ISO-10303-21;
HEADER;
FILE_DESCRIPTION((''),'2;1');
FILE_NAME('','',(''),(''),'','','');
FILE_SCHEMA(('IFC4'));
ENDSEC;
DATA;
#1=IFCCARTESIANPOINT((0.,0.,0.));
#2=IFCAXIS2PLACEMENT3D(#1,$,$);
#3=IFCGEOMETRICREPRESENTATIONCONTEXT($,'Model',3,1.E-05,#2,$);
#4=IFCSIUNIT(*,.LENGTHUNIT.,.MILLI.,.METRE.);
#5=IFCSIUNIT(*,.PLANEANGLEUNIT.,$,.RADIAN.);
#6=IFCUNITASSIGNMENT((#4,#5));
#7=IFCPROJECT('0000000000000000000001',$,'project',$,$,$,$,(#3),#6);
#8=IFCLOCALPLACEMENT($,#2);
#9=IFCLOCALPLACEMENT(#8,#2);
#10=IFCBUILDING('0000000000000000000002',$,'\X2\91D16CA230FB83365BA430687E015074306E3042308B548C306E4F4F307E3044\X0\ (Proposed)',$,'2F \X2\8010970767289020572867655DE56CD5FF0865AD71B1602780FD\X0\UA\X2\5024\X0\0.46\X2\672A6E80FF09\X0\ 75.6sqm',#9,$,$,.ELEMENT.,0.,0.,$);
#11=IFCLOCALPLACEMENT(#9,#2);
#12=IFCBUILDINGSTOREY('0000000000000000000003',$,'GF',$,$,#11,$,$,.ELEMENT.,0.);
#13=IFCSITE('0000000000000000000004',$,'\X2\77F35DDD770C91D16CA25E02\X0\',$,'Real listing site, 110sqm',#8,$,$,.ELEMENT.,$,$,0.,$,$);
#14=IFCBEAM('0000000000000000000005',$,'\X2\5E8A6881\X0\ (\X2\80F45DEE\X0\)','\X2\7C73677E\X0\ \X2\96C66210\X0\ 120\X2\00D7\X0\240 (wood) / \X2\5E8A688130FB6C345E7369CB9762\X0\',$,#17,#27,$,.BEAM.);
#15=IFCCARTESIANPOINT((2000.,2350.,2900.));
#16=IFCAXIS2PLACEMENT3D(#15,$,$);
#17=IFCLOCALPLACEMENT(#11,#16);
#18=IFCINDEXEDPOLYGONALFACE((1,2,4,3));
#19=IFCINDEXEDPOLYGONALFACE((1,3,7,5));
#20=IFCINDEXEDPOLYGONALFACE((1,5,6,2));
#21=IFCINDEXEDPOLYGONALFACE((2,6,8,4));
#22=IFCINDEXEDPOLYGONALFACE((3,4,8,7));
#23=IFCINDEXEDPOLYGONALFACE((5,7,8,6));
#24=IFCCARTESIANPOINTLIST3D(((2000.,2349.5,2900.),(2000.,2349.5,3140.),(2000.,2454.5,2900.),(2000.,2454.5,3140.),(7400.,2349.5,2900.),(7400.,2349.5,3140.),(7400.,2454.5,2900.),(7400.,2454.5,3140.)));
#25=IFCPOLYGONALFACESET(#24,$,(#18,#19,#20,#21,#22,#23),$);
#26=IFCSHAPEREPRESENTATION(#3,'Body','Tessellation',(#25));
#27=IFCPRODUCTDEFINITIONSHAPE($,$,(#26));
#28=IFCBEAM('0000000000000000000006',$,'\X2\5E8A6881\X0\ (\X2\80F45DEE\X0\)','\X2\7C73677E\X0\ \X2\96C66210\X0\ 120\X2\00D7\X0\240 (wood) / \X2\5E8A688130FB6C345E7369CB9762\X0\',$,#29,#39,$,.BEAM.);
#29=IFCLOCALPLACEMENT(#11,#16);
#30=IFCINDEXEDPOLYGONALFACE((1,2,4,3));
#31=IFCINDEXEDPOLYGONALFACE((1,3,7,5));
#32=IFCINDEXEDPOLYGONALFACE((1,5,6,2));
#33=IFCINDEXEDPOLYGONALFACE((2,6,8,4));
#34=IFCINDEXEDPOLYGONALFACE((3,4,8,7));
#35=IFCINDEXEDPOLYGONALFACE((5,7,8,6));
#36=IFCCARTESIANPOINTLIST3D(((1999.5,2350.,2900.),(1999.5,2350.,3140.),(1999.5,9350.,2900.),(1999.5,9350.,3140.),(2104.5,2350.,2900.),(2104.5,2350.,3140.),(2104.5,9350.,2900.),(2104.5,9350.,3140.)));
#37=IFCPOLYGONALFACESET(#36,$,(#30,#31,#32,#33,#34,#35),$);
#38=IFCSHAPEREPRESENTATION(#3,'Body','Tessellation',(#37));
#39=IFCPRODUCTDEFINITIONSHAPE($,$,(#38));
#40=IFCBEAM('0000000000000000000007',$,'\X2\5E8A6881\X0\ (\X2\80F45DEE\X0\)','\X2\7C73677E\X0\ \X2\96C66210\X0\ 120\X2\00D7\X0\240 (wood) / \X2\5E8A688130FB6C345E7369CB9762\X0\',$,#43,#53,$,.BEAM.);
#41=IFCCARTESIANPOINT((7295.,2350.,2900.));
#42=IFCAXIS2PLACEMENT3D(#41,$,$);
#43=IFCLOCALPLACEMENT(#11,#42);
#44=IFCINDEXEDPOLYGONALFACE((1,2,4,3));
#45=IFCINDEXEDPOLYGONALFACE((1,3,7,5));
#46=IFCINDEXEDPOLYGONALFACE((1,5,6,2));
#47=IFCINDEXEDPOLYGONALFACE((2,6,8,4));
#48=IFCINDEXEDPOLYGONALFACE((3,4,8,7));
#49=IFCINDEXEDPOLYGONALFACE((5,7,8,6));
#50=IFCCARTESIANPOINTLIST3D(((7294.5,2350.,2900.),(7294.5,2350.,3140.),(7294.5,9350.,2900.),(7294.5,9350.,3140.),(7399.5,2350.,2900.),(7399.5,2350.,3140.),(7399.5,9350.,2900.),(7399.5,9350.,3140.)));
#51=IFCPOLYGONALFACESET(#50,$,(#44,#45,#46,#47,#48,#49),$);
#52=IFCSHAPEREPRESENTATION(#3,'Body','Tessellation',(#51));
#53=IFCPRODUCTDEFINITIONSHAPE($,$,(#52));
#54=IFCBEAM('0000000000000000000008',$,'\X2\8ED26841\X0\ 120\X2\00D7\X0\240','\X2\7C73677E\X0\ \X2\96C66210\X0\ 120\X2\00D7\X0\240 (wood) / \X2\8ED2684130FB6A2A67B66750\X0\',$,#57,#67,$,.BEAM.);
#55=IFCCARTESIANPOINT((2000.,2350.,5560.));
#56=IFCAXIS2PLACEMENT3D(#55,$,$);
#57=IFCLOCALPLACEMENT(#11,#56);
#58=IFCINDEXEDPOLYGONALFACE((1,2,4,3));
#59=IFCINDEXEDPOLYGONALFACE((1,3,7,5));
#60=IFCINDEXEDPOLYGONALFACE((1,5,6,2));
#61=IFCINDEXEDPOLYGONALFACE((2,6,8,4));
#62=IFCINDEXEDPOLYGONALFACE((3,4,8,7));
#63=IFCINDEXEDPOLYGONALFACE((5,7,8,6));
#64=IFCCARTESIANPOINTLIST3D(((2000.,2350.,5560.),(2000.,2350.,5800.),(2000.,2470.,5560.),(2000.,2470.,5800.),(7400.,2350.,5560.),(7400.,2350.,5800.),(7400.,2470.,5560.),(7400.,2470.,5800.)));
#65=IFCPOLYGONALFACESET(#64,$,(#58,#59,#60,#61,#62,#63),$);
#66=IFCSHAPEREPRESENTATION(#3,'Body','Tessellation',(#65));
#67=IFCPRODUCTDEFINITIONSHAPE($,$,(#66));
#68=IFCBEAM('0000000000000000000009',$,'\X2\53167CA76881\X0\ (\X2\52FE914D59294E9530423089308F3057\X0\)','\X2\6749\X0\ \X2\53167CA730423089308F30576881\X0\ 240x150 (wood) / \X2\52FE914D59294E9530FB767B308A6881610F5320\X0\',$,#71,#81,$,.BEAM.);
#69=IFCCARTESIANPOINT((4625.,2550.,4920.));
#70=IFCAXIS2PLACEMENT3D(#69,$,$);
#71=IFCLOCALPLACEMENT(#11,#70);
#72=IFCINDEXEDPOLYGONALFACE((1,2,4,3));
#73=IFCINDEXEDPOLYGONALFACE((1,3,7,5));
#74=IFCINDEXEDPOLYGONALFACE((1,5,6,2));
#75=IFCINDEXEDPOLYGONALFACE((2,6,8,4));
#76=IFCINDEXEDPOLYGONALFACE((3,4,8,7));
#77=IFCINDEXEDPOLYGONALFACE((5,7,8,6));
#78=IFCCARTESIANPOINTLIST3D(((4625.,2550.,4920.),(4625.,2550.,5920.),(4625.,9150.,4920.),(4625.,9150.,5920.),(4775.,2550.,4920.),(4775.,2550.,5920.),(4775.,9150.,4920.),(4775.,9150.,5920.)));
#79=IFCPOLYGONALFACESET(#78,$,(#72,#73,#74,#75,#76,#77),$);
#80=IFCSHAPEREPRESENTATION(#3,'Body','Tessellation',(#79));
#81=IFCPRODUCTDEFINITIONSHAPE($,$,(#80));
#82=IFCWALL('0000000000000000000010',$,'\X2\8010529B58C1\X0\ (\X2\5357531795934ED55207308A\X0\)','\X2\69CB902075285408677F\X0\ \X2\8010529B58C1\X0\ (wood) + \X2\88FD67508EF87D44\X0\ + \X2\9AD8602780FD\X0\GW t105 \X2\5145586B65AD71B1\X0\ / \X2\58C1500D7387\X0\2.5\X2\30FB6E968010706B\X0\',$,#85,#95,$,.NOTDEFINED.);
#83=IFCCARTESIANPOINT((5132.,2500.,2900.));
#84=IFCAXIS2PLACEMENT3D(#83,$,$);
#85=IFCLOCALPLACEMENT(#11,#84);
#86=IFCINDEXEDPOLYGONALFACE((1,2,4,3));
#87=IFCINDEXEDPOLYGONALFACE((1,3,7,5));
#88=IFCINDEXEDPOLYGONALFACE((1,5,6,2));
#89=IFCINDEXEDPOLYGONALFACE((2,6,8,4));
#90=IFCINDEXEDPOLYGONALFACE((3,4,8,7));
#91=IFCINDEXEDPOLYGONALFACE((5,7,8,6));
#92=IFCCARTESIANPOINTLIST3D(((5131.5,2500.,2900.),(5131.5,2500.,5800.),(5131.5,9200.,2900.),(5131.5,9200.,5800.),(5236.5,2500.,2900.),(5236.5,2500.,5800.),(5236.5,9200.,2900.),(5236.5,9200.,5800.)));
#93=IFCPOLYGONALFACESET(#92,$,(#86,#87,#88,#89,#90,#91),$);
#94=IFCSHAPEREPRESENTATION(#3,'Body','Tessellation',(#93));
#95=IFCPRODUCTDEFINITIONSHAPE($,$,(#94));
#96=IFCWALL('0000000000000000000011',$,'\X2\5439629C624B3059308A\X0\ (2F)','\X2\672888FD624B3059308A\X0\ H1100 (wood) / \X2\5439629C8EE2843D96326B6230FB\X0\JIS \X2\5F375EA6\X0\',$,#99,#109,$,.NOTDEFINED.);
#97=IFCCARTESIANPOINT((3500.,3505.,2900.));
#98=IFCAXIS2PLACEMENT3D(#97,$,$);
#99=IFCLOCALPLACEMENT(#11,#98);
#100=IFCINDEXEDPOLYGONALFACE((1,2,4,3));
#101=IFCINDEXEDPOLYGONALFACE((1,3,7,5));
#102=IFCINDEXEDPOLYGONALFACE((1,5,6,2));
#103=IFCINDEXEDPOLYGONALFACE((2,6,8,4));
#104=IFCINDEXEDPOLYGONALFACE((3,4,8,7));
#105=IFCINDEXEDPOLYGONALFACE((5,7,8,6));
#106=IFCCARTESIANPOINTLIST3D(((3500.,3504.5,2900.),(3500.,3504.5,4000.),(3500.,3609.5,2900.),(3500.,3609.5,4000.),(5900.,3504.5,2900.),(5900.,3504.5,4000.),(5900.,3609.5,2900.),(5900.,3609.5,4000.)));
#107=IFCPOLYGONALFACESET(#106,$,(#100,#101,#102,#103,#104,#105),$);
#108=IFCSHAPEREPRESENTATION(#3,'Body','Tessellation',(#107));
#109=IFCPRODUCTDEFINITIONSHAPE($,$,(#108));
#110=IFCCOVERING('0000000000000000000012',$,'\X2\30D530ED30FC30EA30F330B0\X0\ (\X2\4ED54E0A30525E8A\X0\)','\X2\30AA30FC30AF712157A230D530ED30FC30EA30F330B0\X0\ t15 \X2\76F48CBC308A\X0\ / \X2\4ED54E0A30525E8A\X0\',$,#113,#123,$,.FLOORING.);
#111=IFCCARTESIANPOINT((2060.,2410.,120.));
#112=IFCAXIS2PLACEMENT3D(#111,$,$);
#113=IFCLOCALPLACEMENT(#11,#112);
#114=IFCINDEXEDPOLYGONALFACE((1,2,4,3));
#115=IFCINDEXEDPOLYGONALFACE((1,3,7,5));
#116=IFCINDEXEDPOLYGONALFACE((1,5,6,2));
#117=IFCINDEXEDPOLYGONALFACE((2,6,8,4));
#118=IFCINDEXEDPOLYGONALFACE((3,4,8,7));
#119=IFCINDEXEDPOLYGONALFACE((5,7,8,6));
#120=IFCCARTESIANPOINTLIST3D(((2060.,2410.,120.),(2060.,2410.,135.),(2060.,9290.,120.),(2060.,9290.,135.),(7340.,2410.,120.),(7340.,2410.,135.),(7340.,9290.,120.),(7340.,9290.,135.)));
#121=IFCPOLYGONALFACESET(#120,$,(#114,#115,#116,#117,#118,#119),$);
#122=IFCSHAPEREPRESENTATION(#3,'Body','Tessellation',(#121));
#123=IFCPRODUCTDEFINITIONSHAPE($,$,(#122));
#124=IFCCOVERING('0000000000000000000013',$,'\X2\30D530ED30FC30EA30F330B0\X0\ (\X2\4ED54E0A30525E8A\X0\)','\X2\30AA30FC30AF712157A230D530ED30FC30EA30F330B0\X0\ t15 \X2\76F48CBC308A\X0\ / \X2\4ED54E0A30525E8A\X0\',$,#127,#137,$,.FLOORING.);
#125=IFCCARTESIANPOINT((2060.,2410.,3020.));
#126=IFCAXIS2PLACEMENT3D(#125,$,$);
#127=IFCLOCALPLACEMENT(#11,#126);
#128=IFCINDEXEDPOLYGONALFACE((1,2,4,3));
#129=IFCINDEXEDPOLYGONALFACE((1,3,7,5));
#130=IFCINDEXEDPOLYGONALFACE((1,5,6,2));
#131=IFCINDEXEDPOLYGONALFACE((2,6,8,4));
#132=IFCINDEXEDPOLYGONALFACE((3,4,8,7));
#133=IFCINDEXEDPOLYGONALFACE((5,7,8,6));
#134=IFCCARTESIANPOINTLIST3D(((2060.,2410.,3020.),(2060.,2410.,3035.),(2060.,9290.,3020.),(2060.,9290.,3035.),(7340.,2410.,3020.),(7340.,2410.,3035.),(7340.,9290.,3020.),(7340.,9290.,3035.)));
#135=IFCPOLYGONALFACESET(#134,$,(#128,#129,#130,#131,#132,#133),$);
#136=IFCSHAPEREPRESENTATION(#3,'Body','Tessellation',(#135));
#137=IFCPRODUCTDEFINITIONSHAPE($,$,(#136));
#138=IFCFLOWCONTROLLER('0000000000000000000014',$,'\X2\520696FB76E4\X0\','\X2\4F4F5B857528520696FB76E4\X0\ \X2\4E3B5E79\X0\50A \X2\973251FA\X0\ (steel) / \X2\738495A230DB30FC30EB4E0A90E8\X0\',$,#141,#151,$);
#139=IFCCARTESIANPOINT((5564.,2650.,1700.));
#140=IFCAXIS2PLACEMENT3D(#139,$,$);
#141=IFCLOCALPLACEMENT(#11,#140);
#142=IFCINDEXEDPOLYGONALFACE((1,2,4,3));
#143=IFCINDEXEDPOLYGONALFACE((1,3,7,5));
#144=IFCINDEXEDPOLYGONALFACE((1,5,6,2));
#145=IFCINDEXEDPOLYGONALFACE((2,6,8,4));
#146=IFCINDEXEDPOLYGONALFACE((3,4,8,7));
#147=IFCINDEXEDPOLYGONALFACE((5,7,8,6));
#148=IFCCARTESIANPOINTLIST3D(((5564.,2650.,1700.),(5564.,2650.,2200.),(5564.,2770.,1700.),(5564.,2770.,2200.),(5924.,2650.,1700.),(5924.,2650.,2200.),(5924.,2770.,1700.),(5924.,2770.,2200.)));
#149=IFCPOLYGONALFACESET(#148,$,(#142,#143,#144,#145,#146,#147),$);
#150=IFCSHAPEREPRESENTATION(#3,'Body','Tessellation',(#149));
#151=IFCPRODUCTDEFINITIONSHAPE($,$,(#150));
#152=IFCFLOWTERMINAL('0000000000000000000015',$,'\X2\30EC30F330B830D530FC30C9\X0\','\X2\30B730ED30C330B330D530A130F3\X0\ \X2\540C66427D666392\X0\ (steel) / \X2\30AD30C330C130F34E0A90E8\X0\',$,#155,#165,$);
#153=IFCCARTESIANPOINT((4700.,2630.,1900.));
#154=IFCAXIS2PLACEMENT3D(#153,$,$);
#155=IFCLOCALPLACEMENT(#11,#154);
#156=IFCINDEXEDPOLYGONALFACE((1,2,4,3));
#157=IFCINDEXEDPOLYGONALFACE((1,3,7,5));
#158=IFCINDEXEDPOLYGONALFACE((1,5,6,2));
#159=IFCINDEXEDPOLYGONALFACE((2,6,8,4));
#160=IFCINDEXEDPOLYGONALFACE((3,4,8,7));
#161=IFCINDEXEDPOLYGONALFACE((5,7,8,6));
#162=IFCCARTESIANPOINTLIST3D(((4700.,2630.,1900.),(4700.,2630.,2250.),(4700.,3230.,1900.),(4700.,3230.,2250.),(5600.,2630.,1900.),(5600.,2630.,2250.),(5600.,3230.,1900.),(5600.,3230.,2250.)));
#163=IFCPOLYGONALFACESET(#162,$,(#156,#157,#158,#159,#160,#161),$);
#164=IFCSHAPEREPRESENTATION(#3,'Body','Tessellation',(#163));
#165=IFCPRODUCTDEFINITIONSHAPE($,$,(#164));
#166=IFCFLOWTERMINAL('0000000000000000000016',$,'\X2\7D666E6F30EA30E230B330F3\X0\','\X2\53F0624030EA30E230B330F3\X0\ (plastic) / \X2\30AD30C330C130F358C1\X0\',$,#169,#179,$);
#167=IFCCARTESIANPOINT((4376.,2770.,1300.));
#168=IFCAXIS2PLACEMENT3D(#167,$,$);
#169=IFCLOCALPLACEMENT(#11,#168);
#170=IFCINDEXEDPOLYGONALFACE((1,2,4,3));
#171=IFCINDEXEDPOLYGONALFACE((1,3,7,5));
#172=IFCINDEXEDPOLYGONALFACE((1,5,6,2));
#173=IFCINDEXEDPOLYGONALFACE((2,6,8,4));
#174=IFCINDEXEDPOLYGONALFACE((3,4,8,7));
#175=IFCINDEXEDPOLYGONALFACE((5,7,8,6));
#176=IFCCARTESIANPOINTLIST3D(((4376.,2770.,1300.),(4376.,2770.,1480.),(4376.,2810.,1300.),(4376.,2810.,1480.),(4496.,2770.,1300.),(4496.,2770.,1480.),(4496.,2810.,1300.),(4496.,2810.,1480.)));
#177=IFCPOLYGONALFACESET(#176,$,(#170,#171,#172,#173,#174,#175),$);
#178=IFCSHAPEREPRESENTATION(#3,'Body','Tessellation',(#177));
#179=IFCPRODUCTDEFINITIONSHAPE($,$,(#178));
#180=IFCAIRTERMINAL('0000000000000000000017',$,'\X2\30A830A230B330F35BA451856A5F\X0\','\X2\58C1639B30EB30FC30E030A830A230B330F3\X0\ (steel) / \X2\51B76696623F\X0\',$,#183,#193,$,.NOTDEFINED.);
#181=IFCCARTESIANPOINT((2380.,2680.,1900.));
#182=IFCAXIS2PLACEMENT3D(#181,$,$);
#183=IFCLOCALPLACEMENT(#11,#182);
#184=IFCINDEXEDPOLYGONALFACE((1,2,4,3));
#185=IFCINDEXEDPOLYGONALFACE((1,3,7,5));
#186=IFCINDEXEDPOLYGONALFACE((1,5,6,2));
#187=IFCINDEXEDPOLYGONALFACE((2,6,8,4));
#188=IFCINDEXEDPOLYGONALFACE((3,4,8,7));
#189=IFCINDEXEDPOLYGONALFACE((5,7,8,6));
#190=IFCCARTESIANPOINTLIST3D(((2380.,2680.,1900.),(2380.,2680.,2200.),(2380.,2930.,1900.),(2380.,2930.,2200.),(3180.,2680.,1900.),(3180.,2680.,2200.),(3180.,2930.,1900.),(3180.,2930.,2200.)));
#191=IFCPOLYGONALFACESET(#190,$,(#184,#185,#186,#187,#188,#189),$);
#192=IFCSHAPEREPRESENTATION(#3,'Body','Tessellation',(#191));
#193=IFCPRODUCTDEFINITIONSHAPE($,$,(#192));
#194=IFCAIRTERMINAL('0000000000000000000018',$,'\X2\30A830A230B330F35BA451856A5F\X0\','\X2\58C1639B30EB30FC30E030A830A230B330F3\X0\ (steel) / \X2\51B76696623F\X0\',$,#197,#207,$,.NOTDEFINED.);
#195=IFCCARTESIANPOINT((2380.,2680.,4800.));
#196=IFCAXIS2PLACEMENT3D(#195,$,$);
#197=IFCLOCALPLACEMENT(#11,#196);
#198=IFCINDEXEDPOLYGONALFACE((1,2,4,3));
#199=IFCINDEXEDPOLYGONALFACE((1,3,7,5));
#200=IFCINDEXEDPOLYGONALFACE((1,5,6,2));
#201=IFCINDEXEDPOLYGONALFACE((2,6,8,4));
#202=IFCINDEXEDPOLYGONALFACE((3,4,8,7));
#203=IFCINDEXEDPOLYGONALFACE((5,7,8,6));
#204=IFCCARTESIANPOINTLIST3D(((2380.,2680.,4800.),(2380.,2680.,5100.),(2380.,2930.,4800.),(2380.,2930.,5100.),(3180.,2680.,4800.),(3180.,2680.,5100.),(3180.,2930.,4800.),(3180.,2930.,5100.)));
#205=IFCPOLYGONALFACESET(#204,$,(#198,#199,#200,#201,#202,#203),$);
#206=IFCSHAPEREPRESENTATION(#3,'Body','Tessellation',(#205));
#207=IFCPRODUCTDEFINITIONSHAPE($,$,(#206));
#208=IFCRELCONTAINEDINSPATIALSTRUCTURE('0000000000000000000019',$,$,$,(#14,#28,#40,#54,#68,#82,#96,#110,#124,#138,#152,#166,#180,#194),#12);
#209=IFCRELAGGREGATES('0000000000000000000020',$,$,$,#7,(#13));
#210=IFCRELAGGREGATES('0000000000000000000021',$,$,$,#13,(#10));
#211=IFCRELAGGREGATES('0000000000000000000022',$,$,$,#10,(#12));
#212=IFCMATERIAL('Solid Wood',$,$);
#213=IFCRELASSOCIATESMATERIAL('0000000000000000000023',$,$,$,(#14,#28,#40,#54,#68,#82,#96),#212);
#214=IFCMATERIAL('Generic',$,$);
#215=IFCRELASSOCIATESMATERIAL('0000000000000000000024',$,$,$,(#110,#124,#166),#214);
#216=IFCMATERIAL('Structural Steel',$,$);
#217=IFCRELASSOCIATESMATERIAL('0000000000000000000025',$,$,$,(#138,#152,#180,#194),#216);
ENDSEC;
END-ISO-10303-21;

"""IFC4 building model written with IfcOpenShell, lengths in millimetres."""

from ifc_helpers import new_model, si_unit, frame, frame_2d, origin, place, context, project, spatial, rectangle, extrude, material, element, save


model = new_model("IFC4")

# Units and contexts
model_context = context("Model", 3, precision=1e-05, world=origin())
ifc_project = project(units=[si_unit("LENGTHUNIT", "METRE", prefix="MILLI"), si_unit("PLANEANGLEUNIT", "RADIAN")], contexts=[model_context])

# Site, building, storey
site_placement = place(None, origin())
site = spatial("IfcSite", under=ifc_project, at=site_placement, Name="石川県金沢市", ObjectType="Real listing site, 110sqm", CompositionType="ELEMENT", RefElevation=0.0)
building_placement = place(site_placement, origin())
building = spatial("IfcBuilding", under=site, at=building_placement, Name="金沢・茶室と縁側のある和の住まい (Proposed)", ObjectType="2F 耐震木造在来工法（断熱性能UA値0.46未満） 75.6sqm", CompositionType="ELEMENT", ElevationOfRefHeight=0.0, ElevationOfTerrain=0.0)
storey_placement = place(building_placement, origin())
storey = spatial("IfcBuildingStorey", under=building, at=storey_placement, Name="GF", CompositionType="ELEMENT", Elevation=0.0)

# Shared definitions
ifc_material_1 = material(Name="Solid Wood")

# Beams
beam_1_placement = place(storey_placement, frame((2000.0, 2350.0, 2900.0)))
element("IfcBeam", 1, at=beam_1_placement, inside=storey, material=ifc_material_1, Name="床梁 (胴差)", Description="米松 集成 120×240 (wood) / 床梁・水平構面", PredefinedType="BEAM", context=model_context, shape_type="SweptSolid", body=[
    extrude(rectangle(XDim=5400.0, YDim=105.0, at=frame_2d((2700.0, 52.0))), frame((2000.0, 2350.0, 2900.0)), (0.0, 0.0, 1.0), 240.0),
])
beam_2_placement = place(storey_placement, frame((2000.0, 2350.0, 2900.0)))
element("IfcBeam", 2, at=beam_2_placement, inside=storey, material=ifc_material_1, Name="床梁 (胴差)", Description="米松 集成 120×240 (wood) / 床梁・水平構面", PredefinedType="BEAM", context=model_context, shape_type="SweptSolid", body=[
    extrude(rectangle(XDim=105.0, YDim=7000.0, at=frame_2d((52.0, 3500.0))), frame((2000.0, 2350.0, 2900.0)), (0.0, 0.0, 1.0), 240.0),
])
beam_3_placement = place(storey_placement, frame((7295.0, 2350.0, 2900.0)))
element("IfcBeam", 3, at=beam_3_placement, inside=storey, material=ifc_material_1, Name="床梁 (胴差)", Description="米松 集成 120×240 (wood) / 床梁・水平構面", PredefinedType="BEAM", context=model_context, shape_type="SweptSolid", body=[
    extrude(rectangle(XDim=105.0, YDim=7000.0, at=frame_2d((52.0, 3500.0))), frame((7295.0, 2350.0, 2900.0)), (0.0, 0.0, 1.0), 240.0),
])
beam_4_placement = place(storey_placement, frame((2000.0, 2350.0, 5560.0)))
element("IfcBeam", 4, at=beam_4_placement, inside=storey, material=ifc_material_1, Name="軒桁 120×240", Description="米松 集成 120×240 (wood) / 軒桁・横架材", PredefinedType="BEAM", context=model_context, shape_type="SweptSolid", body=[
    extrude(rectangle(XDim=5400.0, YDim=120.0, at=frame_2d((2700.0, 60.0))), frame((2000.0, 2350.0, 5560.0)), (0.0, 0.0, 1.0), 240.0),
])
beam_5_placement = place(storey_placement, frame((4625.0, 2550.0, 4920.0)))
element("IfcBeam", 5, at=beam_5_placement, inside=storey, material=ifc_material_1, Name="化粧梁 (勾配天井あらわし)", Description="杉 化粧あらわし梁 240x150 (wood) / 勾配天井・登り梁意匠", PredefinedType="BEAM", context=model_context, shape_type="SweptSolid", body=[
    extrude(rectangle(XDim=150.0, YDim=6600.0, at=frame_2d((75.0, 3300.0))), frame((4625.0, 2550.0, 4920.0)), (0.0, 0.0, 1.0), 1000.0),
])

# Walls
wall_1_placement = place(storey_placement, frame((5132.0, 2500.0, 2900.0)))
element("IfcWall", 6, at=wall_1_placement, inside=storey, material=ifc_material_1, Name="耐力壁 (南北間仕切り)", Description="構造用合板 耐力壁 (wood) + 製材軸組 + 高性能GW t105 充填断熱 / 壁倍率2.5・準耐火", PredefinedType="NOTDEFINED", context=model_context, shape_type="SweptSolid", body=[
    extrude(rectangle(XDim=105.0, YDim=6700.0, at=frame_2d((52.0, 3350.0))), frame((5132.0, 2500.0, 2900.0)), (0.0, 0.0, 1.0), 2900.0),
])
wall_2_placement = place(storey_placement, frame((3500.0, 3505.0, 2900.0)))
element("IfcWall", 7, at=wall_2_placement, inside=storey, material=ifc_material_1, Name="吹抜手すり (2F)", Description="木製手すり H1100 (wood) / 吹抜転落防止・JIS 強度", PredefinedType="NOTDEFINED", context=model_context, shape_type="SweptSolid", body=[
    extrude(rectangle(XDim=2400.0, YDim=105.0, at=frame_2d((1200.0, 52.0))), frame((3500.0, 3505.0, 2900.0)), (0.0, 0.0, 1.0), 1100.0),
])

# Coverings
ifc_material_2 = material(Name="Generic")
covering_1_placement = place(storey_placement, frame((2060.0, 2410.0, 120.0)))
element("IfcCovering", 8, at=covering_1_placement, inside=storey, material=ifc_material_2, Name="フローリング (仕上げ床)", Description="オーク無垢フローリング t15 直貼り / 仕上げ床", PredefinedType="FLOORING", context=model_context, shape_type="SweptSolid", body=[
    extrude(rectangle(XDim=5280.0, YDim=6880.0, at=frame_2d((2640.0, 3440.0))), frame((2060.0, 2410.0, 120.0)), (0.0, 0.0, 1.0), 15.0),
])
covering_2_placement = place(storey_placement, frame((2060.0, 2410.0, 3020.0)))
element("IfcCovering", 9, at=covering_2_placement, inside=storey, material=ifc_material_2, Name="フローリング (仕上げ床)", Description="オーク無垢フローリング t15 直貼り / 仕上げ床", PredefinedType="FLOORING", context=model_context, shape_type="SweptSolid", body=[
    extrude(rectangle(XDim=5280.0, YDim=6880.0, at=frame_2d((2640.0, 3440.0))), frame((2060.0, 2410.0, 3020.0)), (0.0, 0.0, 1.0), 15.0),
])

# Flow controller
ifc_material_3 = material(Name="Structural Steel")
flow_controller_placement = place(storey_placement, frame((5564.0, 2650.0, 1700.0)))
element("IfcFlowController", 10, at=flow_controller_placement, inside=storey, material=ifc_material_3, Name="分電盤", Description="住宅用分電盤 主幹50A 露出 (steel) / 玄関ホール上部", context=model_context, shape_type="SweptSolid", body=[
    extrude(rectangle(XDim=360.0, YDim=120.0, at=frame_2d((180.0, 60.0))), frame((5564.0, 2650.0, 1700.0)), (0.0, 0.0, 1.0), 500.0),
])

# Flow terminals
flow_terminal_1_placement = place(storey_placement, frame((4700.0, 2630.0, 1900.0)))
element("IfcFlowTerminal", 11, at=flow_terminal_1_placement, inside=storey, material=ifc_material_3, Name="レンジフード", Description="シロッコファン 同時給排 (steel) / キッチン上部", context=model_context, shape_type="SweptSolid", body=[
    extrude(rectangle(XDim=900.0, YDim=600.0, at=frame_2d((450.0, 300.0))), frame((4700.0, 2630.0, 1900.0)), (0.0, 0.0, 1.0), 350.0),
])
flow_terminal_2_placement = place(storey_placement, frame((4376.0, 2770.0, 1300.0)))
element("IfcFlowTerminal", 12, at=flow_terminal_2_placement, inside=storey, material=ifc_material_2, Name="給湯リモコン", Description="台所リモコン (plastic) / キッチン壁", context=model_context, shape_type="SweptSolid", body=[
    extrude(rectangle(XDim=120.0, YDim=40.0, at=frame_2d((60.0, 20.0))), frame((4376.0, 2770.0, 1300.0)), (0.0, 0.0, 1.0), 180.0),
])

# Air terminals
air_terminal_1_placement = place(storey_placement, frame((2380.0, 2680.0, 1900.0)))
element("IfcAirTerminal", 13, at=air_terminal_1_placement, inside=storey, material=ifc_material_3, Name="エアコン室内機", Description="壁掛ルームエアコン (steel) / 冷暖房", PredefinedType="NOTDEFINED", context=model_context, shape_type="SweptSolid", body=[
    extrude(rectangle(XDim=800.0, YDim=250.0, at=frame_2d((400.0, 125.0))), frame((2380.0, 2680.0, 1900.0)), (0.0, 0.0, 1.0), 300.0),
])
air_terminal_2_placement = place(storey_placement, frame((2380.0, 2680.0, 4800.0)))
element("IfcAirTerminal", 14, at=air_terminal_2_placement, inside=storey, material=ifc_material_3, Name="エアコン室内機", Description="壁掛ルームエアコン (steel) / 冷暖房", PredefinedType="NOTDEFINED", context=model_context, shape_type="SweptSolid", body=[
    extrude(rectangle(XDim=800.0, YDim=250.0, at=frame_2d((400.0, 125.0))), frame((2380.0, 2680.0, 4800.0)), (0.0, 0.0, 1.0), 300.0),
])

save(model, "model.ifc")
